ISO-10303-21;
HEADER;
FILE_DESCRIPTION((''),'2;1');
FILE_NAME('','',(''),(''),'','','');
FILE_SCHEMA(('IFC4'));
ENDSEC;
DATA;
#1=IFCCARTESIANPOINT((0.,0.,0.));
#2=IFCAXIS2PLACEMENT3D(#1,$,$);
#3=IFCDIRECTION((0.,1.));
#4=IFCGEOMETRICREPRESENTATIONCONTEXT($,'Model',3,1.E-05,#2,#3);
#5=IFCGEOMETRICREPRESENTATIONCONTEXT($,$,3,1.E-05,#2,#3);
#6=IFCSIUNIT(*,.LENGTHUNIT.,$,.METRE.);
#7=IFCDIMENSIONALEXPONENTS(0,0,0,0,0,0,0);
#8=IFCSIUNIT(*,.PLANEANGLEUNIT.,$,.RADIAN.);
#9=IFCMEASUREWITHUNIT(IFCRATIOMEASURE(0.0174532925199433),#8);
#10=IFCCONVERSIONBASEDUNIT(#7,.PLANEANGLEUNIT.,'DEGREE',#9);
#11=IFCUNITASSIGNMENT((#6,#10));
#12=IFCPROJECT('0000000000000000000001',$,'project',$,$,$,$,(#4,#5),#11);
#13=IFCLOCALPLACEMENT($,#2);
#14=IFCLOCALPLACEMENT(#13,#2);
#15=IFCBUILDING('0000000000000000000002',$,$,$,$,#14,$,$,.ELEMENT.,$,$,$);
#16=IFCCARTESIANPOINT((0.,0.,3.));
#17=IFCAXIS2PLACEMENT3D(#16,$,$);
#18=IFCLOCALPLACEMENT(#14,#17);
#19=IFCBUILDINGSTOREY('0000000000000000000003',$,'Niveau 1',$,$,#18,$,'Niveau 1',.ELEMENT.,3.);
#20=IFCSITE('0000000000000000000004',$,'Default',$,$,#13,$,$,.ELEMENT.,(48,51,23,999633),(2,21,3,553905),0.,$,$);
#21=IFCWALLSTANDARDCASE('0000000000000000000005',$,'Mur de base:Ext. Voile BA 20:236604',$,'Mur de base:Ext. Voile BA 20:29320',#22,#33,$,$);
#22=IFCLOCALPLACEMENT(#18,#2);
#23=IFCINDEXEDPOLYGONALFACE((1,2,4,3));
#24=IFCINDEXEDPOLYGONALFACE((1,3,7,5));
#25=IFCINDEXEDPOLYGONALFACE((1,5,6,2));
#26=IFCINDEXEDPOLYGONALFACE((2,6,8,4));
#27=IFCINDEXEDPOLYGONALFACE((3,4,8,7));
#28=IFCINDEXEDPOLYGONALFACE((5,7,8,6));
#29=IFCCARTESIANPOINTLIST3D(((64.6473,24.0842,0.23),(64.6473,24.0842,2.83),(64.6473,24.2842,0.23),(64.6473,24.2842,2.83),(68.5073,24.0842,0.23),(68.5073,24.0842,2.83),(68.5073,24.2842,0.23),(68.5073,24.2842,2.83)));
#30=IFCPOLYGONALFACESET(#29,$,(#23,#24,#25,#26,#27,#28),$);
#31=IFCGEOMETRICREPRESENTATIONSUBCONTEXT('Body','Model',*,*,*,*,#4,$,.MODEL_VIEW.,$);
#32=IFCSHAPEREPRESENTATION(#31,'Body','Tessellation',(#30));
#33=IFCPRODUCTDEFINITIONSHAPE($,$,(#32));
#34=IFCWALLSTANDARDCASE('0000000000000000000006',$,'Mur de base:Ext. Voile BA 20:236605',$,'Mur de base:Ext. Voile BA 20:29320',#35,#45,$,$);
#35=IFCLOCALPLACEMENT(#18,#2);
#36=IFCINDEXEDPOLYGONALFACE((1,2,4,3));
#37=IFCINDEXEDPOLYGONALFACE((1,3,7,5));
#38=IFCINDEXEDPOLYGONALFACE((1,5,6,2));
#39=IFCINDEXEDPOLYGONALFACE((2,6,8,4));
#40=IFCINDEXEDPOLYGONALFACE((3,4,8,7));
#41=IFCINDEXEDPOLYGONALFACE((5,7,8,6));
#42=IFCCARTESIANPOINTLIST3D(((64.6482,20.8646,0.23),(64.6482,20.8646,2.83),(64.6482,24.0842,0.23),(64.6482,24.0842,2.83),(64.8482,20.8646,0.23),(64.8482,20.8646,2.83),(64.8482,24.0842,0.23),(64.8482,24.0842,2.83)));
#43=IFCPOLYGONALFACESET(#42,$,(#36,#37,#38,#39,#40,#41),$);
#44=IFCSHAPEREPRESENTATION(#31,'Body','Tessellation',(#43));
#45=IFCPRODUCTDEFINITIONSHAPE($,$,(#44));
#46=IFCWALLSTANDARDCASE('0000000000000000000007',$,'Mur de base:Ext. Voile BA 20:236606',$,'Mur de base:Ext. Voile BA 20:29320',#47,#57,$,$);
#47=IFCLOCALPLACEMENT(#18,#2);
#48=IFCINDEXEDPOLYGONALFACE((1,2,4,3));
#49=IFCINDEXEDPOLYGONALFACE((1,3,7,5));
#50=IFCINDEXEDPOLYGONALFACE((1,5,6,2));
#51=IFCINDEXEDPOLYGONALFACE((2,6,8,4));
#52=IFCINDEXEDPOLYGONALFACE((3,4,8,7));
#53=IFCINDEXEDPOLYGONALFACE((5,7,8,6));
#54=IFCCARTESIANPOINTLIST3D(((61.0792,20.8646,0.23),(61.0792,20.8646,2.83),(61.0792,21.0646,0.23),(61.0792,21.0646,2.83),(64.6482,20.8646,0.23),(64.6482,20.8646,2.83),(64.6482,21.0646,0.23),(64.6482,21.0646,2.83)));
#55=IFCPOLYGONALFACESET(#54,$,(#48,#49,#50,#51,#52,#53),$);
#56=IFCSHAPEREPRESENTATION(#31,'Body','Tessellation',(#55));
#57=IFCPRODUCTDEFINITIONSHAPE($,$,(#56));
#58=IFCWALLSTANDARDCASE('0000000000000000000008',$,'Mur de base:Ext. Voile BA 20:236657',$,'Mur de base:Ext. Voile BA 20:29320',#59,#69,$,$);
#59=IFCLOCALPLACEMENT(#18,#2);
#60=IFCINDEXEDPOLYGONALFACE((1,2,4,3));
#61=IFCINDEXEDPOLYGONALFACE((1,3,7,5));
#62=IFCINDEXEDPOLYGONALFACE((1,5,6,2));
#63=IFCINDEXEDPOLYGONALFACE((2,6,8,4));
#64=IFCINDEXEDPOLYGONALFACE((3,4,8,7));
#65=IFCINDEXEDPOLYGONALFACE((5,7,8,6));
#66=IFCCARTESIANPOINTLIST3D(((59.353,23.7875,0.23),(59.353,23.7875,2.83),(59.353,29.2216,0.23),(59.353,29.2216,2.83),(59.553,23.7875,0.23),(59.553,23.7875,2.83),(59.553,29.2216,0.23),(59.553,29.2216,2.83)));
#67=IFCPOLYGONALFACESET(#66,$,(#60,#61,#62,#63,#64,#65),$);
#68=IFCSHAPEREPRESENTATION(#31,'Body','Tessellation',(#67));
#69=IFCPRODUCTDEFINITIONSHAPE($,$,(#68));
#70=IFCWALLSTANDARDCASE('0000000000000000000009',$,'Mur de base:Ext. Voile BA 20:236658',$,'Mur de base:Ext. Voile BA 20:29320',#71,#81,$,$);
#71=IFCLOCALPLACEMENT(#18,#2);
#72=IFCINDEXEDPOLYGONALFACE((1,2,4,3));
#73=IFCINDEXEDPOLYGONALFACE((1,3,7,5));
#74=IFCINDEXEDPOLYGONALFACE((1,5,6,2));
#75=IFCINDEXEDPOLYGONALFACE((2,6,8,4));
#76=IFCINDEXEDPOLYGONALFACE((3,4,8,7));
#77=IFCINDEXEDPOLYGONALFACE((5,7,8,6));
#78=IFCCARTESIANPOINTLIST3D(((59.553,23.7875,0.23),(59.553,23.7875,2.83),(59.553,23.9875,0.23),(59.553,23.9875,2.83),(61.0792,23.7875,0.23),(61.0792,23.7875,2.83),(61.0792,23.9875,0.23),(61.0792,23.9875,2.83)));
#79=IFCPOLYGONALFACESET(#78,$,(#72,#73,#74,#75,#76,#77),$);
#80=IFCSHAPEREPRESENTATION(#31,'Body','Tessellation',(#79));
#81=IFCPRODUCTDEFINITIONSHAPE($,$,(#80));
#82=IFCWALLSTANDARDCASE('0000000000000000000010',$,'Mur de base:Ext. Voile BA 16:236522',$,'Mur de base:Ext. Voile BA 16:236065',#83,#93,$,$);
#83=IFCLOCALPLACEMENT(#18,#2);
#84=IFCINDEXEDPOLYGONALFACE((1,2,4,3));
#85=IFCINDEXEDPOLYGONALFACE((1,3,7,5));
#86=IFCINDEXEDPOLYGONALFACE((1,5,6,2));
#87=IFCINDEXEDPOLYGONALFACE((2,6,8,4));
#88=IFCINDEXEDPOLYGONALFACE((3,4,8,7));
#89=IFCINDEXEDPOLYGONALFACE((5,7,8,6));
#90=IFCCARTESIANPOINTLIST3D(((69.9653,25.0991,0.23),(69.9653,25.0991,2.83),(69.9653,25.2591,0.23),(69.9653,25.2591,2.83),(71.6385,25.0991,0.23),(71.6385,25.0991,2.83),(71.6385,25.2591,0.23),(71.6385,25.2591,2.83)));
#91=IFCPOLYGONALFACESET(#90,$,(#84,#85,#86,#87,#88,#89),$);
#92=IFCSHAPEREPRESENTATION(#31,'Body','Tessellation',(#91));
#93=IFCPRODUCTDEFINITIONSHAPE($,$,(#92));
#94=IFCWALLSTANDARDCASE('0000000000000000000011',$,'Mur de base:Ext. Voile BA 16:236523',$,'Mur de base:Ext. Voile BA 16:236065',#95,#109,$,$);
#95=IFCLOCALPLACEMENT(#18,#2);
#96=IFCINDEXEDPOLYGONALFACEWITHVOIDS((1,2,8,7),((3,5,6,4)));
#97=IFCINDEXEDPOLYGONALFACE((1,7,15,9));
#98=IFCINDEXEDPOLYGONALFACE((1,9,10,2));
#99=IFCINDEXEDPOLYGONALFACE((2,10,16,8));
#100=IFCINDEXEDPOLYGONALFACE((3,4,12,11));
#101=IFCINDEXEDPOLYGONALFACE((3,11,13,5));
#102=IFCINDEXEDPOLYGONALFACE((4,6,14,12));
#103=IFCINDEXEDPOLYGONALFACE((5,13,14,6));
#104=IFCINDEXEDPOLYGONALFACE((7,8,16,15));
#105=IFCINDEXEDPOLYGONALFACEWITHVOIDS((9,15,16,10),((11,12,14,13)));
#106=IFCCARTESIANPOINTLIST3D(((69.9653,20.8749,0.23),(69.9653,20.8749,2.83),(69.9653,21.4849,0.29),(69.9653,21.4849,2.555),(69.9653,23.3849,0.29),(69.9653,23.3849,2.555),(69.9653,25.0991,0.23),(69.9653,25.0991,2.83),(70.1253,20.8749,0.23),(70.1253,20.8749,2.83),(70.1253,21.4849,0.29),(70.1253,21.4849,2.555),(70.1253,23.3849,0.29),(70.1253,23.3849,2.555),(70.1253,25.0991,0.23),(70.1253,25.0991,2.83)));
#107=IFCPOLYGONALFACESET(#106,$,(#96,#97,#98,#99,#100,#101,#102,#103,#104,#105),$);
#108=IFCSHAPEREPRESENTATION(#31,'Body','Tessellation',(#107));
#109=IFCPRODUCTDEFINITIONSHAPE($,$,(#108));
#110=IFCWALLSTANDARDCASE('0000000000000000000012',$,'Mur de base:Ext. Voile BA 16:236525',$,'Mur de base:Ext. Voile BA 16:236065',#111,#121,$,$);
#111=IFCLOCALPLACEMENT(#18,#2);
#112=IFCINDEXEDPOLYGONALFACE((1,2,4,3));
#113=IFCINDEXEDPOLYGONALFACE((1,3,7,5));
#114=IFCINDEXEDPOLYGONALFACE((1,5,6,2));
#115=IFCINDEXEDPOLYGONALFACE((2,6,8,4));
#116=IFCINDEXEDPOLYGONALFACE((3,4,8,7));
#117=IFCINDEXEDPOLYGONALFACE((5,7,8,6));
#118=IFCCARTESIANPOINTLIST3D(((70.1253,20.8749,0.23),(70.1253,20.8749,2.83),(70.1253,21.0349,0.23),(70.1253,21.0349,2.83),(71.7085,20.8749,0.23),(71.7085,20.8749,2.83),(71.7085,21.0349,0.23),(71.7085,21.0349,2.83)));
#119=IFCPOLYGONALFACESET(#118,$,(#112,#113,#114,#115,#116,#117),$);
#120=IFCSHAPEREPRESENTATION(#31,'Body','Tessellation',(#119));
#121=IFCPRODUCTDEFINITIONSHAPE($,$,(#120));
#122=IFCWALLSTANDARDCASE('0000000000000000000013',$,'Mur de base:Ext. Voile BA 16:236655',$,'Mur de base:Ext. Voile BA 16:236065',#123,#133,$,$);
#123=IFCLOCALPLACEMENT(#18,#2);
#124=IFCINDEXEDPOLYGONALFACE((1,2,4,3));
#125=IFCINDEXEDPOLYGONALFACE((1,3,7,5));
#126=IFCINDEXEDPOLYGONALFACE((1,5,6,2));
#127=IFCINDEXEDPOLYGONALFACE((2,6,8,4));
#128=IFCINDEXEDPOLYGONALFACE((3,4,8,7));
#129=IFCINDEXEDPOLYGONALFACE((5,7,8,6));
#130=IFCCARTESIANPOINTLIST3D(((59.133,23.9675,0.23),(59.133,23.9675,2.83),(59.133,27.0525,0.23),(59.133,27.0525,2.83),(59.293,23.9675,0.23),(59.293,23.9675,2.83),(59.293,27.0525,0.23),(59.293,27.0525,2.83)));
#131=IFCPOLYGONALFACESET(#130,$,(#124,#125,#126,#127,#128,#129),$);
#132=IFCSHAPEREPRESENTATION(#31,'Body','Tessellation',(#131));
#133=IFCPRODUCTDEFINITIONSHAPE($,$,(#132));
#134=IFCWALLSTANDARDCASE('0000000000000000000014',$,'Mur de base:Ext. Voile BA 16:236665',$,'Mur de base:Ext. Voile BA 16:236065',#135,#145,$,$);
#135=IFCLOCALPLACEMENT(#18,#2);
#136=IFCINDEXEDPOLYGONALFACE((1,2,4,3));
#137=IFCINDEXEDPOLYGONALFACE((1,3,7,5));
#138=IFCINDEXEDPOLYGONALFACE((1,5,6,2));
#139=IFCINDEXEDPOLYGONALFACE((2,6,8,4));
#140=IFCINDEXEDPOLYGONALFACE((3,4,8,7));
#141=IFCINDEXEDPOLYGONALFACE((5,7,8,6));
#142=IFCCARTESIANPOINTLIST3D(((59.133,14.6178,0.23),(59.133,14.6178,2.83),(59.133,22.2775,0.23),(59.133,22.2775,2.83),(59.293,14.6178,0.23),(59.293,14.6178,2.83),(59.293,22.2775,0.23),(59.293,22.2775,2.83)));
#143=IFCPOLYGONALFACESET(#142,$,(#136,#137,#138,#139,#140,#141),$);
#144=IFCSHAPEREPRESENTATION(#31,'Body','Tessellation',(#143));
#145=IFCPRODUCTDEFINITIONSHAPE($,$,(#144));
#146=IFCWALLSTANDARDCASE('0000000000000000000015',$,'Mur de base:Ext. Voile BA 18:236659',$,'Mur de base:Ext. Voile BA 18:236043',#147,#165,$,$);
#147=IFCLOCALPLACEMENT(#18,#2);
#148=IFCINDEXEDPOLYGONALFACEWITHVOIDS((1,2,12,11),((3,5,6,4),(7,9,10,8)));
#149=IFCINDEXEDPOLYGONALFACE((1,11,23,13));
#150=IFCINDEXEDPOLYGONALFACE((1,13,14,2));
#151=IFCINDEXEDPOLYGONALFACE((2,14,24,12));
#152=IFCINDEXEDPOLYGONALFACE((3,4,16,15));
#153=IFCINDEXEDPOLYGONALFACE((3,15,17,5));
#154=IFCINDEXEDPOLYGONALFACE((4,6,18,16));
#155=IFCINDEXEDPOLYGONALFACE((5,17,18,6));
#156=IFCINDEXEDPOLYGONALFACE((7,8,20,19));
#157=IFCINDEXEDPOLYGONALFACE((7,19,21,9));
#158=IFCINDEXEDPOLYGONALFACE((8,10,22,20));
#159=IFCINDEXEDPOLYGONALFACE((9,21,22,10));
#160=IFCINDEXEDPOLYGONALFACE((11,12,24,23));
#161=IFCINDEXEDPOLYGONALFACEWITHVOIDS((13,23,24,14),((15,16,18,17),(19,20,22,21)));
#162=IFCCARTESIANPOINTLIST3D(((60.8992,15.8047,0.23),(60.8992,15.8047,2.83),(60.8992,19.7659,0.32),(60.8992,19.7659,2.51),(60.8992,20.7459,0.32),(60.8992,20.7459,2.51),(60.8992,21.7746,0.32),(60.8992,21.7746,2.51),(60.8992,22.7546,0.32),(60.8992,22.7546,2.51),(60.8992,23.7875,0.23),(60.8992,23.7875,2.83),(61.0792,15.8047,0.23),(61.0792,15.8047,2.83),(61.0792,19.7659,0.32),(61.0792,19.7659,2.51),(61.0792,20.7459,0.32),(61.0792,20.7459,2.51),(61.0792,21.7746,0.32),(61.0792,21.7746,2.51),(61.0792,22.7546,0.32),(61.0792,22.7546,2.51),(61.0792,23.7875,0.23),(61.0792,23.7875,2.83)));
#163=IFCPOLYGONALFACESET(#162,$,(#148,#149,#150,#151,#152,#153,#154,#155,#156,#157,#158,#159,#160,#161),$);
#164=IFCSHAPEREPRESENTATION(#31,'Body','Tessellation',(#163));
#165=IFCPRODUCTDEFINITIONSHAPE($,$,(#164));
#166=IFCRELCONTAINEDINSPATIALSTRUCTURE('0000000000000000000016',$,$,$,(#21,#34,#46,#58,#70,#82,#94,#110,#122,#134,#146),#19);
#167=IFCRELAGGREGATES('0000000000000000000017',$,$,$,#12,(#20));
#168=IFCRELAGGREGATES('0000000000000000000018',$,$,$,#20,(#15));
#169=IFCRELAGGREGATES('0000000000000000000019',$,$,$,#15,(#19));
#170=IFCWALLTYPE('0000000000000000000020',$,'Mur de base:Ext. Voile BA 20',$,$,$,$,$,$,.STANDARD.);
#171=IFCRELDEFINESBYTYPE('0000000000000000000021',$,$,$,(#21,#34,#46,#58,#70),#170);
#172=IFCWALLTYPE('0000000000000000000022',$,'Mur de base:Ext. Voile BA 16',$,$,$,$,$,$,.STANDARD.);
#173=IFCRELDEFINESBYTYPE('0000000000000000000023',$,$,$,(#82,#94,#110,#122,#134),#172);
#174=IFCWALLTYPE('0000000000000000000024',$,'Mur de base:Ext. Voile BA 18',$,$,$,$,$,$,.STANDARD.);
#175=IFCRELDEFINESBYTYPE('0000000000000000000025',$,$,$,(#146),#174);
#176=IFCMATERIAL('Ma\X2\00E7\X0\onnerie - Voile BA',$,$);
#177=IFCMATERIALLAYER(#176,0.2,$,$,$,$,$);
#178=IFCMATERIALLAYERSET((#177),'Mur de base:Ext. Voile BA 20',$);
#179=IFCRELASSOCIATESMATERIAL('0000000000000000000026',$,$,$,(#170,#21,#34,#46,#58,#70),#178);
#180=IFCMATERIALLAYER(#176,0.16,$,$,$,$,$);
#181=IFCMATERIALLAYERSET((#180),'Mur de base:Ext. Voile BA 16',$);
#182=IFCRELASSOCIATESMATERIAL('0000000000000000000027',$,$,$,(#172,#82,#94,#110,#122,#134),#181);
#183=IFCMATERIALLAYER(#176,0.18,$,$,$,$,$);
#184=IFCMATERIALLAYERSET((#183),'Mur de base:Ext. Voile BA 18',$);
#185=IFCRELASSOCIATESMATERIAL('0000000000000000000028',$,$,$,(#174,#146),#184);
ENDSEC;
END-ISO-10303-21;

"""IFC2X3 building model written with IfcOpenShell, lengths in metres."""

from ifc_helpers import new_model, entity, si_unit, converted_unit, direction, frame, frame_2d, origin, origin_2d_with_axis, place, context, subcontext, project, spatial, rectangle, extrude, material, layer, layer_set, layer_usage, type_object, element, save


model = new_model("IFC2X3")

# Units and contexts
model_context = context("Model", 3, precision=1e-05, world=origin(), true_north=direction((0.0, 1.0)))
context_of_model = context(None, 3, precision=1e-05, world=origin(), true_north=direction((0.0, 1.0)))
body_context = subcontext(model_context, "Body", "Model", "MODEL_VIEW")
ifc_project = project(units=[si_unit("LENGTHUNIT", "METRE"), converted_unit("PLANEANGLEUNIT", "DEGREE", entity("IfcRatioMeasure", 0.0174532925199433), si_unit("PLANEANGLEUNIT", "RADIAN"), dimensions=[0, 0, 0, 0, 0, 0, 0])], contexts=[model_context, context_of_model])

# Site, building, storey
site_placement = place(None, origin())
site = spatial("IfcSite", under=ifc_project, at=site_placement, Name="Default", CompositionType="ELEMENT", RefLatitude=(48, 51, 23, 999633), RefLongitude=(2, 21, 3, 553905), RefElevation=0.0)
building_placement = place(site_placement, origin())
building = spatial("IfcBuilding", under=site, at=building_placement, CompositionType="ELEMENT")
storey_placement = place(building_placement, frame((0.0, 0.0, 3.0)))
storey = spatial("IfcBuildingStorey", under=building, at=storey_placement, Name="Niveau 1", LongName="Niveau 1", CompositionType="ELEMENT", Elevation=3.0)

# Walls
ifc_material = material(Name="Maçonnerie - Voile BA")
ifc_layer_1 = layer(ifc_material, 0.2)
ifc_layer_set_1 = layer_set([ifc_layer_1], Name="Mur de base:Ext. Voile BA 20")
ifc_layer_usage_1 = layer_usage(ifc_layer_set_1, "AXIS2", "NEGATIVE", 0.1)
wall_type_1 = type_object("IfcWallType", Name="Mur de base:Ext. Voile BA 20", PredefinedType="STANDARD", material=ifc_layer_set_1)
wall_1_placement = place(storey_placement, frame((68.5073, 24.1842, 0.23), z_axis=(0.0, 0.0, 1.0), x_axis=(-1.0, 0.0, 0.0)))
element("IfcWallStandardCase", 1, at=wall_1_placement, inside=storey, type_object=wall_type_1, material=ifc_layer_usage_1, Name="Mur de base:Ext. Voile BA 20:236604", ObjectType="Mur de base:Ext. Voile BA 20:29320", context=body_context, shape_type="SweptSolid", body=[
    extrude(rectangle(XDim=3.86, YDim=0.2, at=frame_2d((1.93, 0.0), x_axis=(-1.0, 0.0))), origin(), (0.0, 0.0, 1.0), 2.6),
])
ifc_layer_usage_2 = layer_usage(ifc_layer_set_1, "AXIS2", "NEGATIVE", 0.1)
wall_2_placement = place(storey_placement, frame((64.7482, 24.0842, 0.23), z_axis=(0.0, 0.0, 1.0), x_axis=(0.0, -1.0, 0.0)))
element("IfcWallStandardCase", 2, at=wall_2_placement, inside=storey, type_object=wall_type_1, material=ifc_layer_usage_2, Name="Mur de base:Ext. Voile BA 20:236605", ObjectType="Mur de base:Ext. Voile BA 20:29320", context=body_context, shape_type="SweptSolid", body=[
    extrude(rectangle(XDim=3.2196, YDim=0.2, at=frame_2d((1.6098, 0.0), x_axis=(-1.0, 0.0))), origin(), (0.0, 0.0, 1.0), 2.6),
])
ifc_layer_usage_3 = layer_usage(ifc_layer_set_1, "AXIS2", "NEGATIVE", 0.1)
wall_3_placement = place(storey_placement, frame((64.6482, 20.9646, 0.23), z_axis=(0.0, 0.0, 1.0), x_axis=(-1.0, 0.0, 0.0)))
element("IfcWallStandardCase", 3, at=wall_3_placement, inside=storey, type_object=wall_type_1, material=ifc_layer_usage_3, Name="Mur de base:Ext. Voile BA 20:236606", ObjectType="Mur de base:Ext. Voile BA 20:29320", context=body_context, shape_type="SweptSolid", body=[
    extrude(rectangle(XDim=3.5689, YDim=0.2, at=frame_2d((1.7845, 0.0), x_axis=(-1.0, 0.0))), origin(), (0.0, 0.0, 1.0), 2.6),
])
ifc_layer_usage_4 = layer_usage(ifc_layer_set_1, "AXIS2", "NEGATIVE", 0.1)
wall_4_placement = place(storey_placement, frame((59.453, 29.2216, 0.23), z_axis=(0.0, 0.0, 1.0), x_axis=(0.0, -1.0, 0.0)))
element("IfcWallStandardCase", 4, at=wall_4_placement, inside=storey, type_object=wall_type_1, material=ifc_layer_usage_4, Name="Mur de base:Ext. Voile BA 20:236657", ObjectType="Mur de base:Ext. Voile BA 20:29320", context=body_context, shape_type="SweptSolid", body=[
    extrude(rectangle(XDim=5.4341, YDim=0.2, at=frame_2d((2.717, 0.0), x_axis=(-1.0, 0.0))), origin(), (0.0, 0.0, 1.0), 2.6),
])
ifc_layer_usage_5 = layer_usage(ifc_layer_set_1, "AXIS2", "POSITIVE", -0.1)
wall_5_placement = place(storey_placement, frame((59.553, 23.8875, 0.23)))
element("IfcWallStandardCase", 5, at=wall_5_placement, inside=storey, type_object=wall_type_1, material=ifc_layer_usage_5, Name="Mur de base:Ext. Voile BA 20:236658", ObjectType="Mur de base:Ext. Voile BA 20:29320", context=body_context, shape_type="SweptSolid", body=[
    extrude(rectangle(XDim=1.5262, YDim=0.2, at=frame_2d((0.7631, 0.0), x_axis=(-1.0, 0.0))), origin(), (0.0, 0.0, 1.0), 2.6),
])

# Wall
ifc_layer_2 = layer(ifc_material, 0.16)
ifc_layer_set_2 = layer_set([ifc_layer_2], Name="Mur de base:Ext. Voile BA 16")
ifc_layer_usage_6 = layer_usage(ifc_layer_set_2, "AXIS2", "NEGATIVE", 0.08)
wall_type_2 = type_object("IfcWallType", Name="Mur de base:Ext. Voile BA 16", PredefinedType="STANDARD", material=ifc_layer_set_2)
wall_6_placement = place(storey_placement, frame((71.6385, 25.1791, 0.23), z_axis=(0.0, 0.0, 1.0), x_axis=(-1.0, 0.0, 0.0)))
element("IfcWallStandardCase", 6, at=wall_6_placement, inside=storey, type_object=wall_type_2, material=ifc_layer_usage_6, Name="Mur de base:Ext. Voile BA 16:236522", ObjectType="Mur de base:Ext. Voile BA 16:236065", context=body_context, shape_type="SweptSolid", body=[
    extrude(rectangle(XDim=1.6732, YDim=0.16, at=frame_2d((0.8366, 0.0), x_axis=(-1.0, 0.0))), origin(), (0.0, 0.0, 1.0), 2.6),
])

# Wall, opening
ifc_layer_usage_7 = layer_usage(ifc_layer_set_2, "AXIS2", "NEGATIVE", 0.08)
wall_7_placement = place(storey_placement, frame((70.0453, 25.0991, 0.23), z_axis=(0.0, 0.0, 1.0), x_axis=(0.0, -1.0, 0.0)))
wall_7 = element("IfcWallStandardCase", 7, at=wall_7_placement, inside=storey, type_object=wall_type_2, material=ifc_layer_usage_7, Name="Mur de base:Ext. Voile BA 16:236523", ObjectType="Mur de base:Ext. Voile BA 16:236065", context=body_context, shape_type="SweptSolid", body=[
    extrude(rectangle(XDim=4.2242, YDim=0.16, at=frame_2d((2.1121, 0.0), x_axis=(-1.0, 0.0))), origin(), (0.0, 0.0, 1.0), 2.6),
])
opening_1_placement = place(wall_7_placement, origin())
element("IfcOpeningElement", 8, at=opening_1_placement, cuts=wall_7, ObjectType="Opening", context=body_context, shape_type="SweptSolid", body=[
    extrude(rectangle(XDim=2.265, YDim=1.9, at=origin_2d_with_axis()), frame((2.6642, -0.08, 1.1925), z_axis=(0.0, 1.0, 0.0), x_axis=(0.0, 0.0, -1.0)), (0.0, 0.0, 1.0), 0.16),
])

# Wall
ifc_layer_usage_8 = layer_usage(ifc_layer_set_2, "AXIS2", "NEGATIVE", 0.08)
wall_8_placement = place(storey_placement, frame((70.1253, 20.9549, 0.23)))
element("IfcWallStandardCase", 9, at=wall_8_placement, inside=storey, type_object=wall_type_2, material=ifc_layer_usage_8, Name="Mur de base:Ext. Voile BA 16:236525", ObjectType="Mur de base:Ext. Voile BA 16:236065", context=body_context, shape_type="SweptSolid", body=[
    extrude(rectangle(XDim=1.5832, YDim=0.16, at=frame_2d((0.7916, 0.0), x_axis=(-1.0, 0.0))), origin(), (0.0, 0.0, 1.0), 2.6),
])

# Walls
ifc_layer_usage_9 = layer_usage(ifc_layer_set_2, "AXIS2", "NEGATIVE", 0.08)
wall_9_placement = place(storey_placement, frame((59.213, 23.9675, 0.23), z_axis=(0.0, 0.0, 1.0), x_axis=(0.0, 1.0, 0.0)))
element("IfcWallStandardCase", 10, at=wall_9_placement, inside=storey, type_object=wall_type_2, material=ifc_layer_usage_9, Name="Mur de base:Ext. Voile BA 16:236655", ObjectType="Mur de base:Ext. Voile BA 16:236065", context=body_context, shape_type="SweptSolid", body=[
    extrude(rectangle(XDim=3.085, YDim=0.16, at=frame_2d((1.5425, 0.0), x_axis=(-1.0, 0.0))), origin(), (0.0, 0.0, 1.0), 2.6),
])
ifc_layer_usage_10 = layer_usage(ifc_layer_set_2, "AXIS2", "NEGATIVE", 0.08)
wall_10_placement = place(storey_placement, frame((59.213, 22.2775, 0.23), z_axis=(0.0, 0.0, 1.0), x_axis=(0.0, -1.0, 0.0)))
element("IfcWallStandardCase", 11, at=wall_10_placement, inside=storey, type_object=wall_type_2, material=ifc_layer_usage_10, Name="Mur de base:Ext. Voile BA 16:236665", ObjectType="Mur de base:Ext. Voile BA 16:236065", context=body_context, shape_type="SweptSolid", body=[
    extrude(rectangle(XDim=7.6597, YDim=0.16, at=frame_2d((3.8298, 0.0), x_axis=(-1.0, 0.0))), origin(), (0.0, 0.0, 1.0), 2.6),
])

# Wall, openings
ifc_layer_3 = layer(ifc_material, 0.18)
ifc_layer_set_3 = layer_set([ifc_layer_3], Name="Mur de base:Ext. Voile BA 18")
ifc_layer_usage_11 = layer_usage(ifc_layer_set_3, "AXIS2", "POSITIVE", -0.09)
wall_type_3 = type_object("IfcWallType", Name="Mur de base:Ext. Voile BA 18", PredefinedType="STANDARD", material=ifc_layer_set_3)
wall_11_placement = place(storey_placement, frame((60.9892, 23.7875, 0.23), z_axis=(0.0, 0.0, 1.0), x_axis=(0.0, -1.0, 0.0)))
wall_11 = element("IfcWallStandardCase", 12, at=wall_11_placement, inside=storey, type_object=wall_type_3, material=ifc_layer_usage_11, Name="Mur de base:Ext. Voile BA 18:236659", ObjectType="Mur de base:Ext. Voile BA 18:236043", context=body_context, shape_type="SweptSolid", body=[
    extrude(rectangle(XDim=7.9828, YDim=0.18, at=frame_2d((3.9914, 0.0), x_axis=(-1.0, 0.0))), origin(), (0.0, 0.0, 1.0), 2.6),
])
opening_2_placement = place(wall_11_placement, origin())
element("IfcOpeningElement", 13, at=opening_2_placement, cuts=wall_11, ObjectType="Opening", context=body_context, shape_type="SweptSolid", body=[
    extrude(rectangle(XDim=2.19, YDim=0.98, at=frame_2d((0.0, 0.0), x_axis=(1.0, 0.0))), frame((1.5229, -0.09, 1.185), z_axis=(0.0, 1.0, 0.0), x_axis=(0.0, 0.0, -1.0)), (0.0, 0.0, 1.0), 0.18),
])
opening_3_placement = place(wall_11_placement, origin())
element("IfcOpeningElement", 14, at=opening_3_placement, cuts=wall_11, ObjectType="Opening", context=body_context, shape_type="SweptSolid", body=[
    extrude(rectangle(XDim=2.19, YDim=0.98, at=origin_2d_with_axis()), frame((3.5316, -0.09, 1.185), z_axis=(0.0, 1.0, 0.0), x_axis=(0.0, 0.0, -1.0)), (0.0, 0.0, 1.0), 0.18),
])

save(model, "model.ifc")
